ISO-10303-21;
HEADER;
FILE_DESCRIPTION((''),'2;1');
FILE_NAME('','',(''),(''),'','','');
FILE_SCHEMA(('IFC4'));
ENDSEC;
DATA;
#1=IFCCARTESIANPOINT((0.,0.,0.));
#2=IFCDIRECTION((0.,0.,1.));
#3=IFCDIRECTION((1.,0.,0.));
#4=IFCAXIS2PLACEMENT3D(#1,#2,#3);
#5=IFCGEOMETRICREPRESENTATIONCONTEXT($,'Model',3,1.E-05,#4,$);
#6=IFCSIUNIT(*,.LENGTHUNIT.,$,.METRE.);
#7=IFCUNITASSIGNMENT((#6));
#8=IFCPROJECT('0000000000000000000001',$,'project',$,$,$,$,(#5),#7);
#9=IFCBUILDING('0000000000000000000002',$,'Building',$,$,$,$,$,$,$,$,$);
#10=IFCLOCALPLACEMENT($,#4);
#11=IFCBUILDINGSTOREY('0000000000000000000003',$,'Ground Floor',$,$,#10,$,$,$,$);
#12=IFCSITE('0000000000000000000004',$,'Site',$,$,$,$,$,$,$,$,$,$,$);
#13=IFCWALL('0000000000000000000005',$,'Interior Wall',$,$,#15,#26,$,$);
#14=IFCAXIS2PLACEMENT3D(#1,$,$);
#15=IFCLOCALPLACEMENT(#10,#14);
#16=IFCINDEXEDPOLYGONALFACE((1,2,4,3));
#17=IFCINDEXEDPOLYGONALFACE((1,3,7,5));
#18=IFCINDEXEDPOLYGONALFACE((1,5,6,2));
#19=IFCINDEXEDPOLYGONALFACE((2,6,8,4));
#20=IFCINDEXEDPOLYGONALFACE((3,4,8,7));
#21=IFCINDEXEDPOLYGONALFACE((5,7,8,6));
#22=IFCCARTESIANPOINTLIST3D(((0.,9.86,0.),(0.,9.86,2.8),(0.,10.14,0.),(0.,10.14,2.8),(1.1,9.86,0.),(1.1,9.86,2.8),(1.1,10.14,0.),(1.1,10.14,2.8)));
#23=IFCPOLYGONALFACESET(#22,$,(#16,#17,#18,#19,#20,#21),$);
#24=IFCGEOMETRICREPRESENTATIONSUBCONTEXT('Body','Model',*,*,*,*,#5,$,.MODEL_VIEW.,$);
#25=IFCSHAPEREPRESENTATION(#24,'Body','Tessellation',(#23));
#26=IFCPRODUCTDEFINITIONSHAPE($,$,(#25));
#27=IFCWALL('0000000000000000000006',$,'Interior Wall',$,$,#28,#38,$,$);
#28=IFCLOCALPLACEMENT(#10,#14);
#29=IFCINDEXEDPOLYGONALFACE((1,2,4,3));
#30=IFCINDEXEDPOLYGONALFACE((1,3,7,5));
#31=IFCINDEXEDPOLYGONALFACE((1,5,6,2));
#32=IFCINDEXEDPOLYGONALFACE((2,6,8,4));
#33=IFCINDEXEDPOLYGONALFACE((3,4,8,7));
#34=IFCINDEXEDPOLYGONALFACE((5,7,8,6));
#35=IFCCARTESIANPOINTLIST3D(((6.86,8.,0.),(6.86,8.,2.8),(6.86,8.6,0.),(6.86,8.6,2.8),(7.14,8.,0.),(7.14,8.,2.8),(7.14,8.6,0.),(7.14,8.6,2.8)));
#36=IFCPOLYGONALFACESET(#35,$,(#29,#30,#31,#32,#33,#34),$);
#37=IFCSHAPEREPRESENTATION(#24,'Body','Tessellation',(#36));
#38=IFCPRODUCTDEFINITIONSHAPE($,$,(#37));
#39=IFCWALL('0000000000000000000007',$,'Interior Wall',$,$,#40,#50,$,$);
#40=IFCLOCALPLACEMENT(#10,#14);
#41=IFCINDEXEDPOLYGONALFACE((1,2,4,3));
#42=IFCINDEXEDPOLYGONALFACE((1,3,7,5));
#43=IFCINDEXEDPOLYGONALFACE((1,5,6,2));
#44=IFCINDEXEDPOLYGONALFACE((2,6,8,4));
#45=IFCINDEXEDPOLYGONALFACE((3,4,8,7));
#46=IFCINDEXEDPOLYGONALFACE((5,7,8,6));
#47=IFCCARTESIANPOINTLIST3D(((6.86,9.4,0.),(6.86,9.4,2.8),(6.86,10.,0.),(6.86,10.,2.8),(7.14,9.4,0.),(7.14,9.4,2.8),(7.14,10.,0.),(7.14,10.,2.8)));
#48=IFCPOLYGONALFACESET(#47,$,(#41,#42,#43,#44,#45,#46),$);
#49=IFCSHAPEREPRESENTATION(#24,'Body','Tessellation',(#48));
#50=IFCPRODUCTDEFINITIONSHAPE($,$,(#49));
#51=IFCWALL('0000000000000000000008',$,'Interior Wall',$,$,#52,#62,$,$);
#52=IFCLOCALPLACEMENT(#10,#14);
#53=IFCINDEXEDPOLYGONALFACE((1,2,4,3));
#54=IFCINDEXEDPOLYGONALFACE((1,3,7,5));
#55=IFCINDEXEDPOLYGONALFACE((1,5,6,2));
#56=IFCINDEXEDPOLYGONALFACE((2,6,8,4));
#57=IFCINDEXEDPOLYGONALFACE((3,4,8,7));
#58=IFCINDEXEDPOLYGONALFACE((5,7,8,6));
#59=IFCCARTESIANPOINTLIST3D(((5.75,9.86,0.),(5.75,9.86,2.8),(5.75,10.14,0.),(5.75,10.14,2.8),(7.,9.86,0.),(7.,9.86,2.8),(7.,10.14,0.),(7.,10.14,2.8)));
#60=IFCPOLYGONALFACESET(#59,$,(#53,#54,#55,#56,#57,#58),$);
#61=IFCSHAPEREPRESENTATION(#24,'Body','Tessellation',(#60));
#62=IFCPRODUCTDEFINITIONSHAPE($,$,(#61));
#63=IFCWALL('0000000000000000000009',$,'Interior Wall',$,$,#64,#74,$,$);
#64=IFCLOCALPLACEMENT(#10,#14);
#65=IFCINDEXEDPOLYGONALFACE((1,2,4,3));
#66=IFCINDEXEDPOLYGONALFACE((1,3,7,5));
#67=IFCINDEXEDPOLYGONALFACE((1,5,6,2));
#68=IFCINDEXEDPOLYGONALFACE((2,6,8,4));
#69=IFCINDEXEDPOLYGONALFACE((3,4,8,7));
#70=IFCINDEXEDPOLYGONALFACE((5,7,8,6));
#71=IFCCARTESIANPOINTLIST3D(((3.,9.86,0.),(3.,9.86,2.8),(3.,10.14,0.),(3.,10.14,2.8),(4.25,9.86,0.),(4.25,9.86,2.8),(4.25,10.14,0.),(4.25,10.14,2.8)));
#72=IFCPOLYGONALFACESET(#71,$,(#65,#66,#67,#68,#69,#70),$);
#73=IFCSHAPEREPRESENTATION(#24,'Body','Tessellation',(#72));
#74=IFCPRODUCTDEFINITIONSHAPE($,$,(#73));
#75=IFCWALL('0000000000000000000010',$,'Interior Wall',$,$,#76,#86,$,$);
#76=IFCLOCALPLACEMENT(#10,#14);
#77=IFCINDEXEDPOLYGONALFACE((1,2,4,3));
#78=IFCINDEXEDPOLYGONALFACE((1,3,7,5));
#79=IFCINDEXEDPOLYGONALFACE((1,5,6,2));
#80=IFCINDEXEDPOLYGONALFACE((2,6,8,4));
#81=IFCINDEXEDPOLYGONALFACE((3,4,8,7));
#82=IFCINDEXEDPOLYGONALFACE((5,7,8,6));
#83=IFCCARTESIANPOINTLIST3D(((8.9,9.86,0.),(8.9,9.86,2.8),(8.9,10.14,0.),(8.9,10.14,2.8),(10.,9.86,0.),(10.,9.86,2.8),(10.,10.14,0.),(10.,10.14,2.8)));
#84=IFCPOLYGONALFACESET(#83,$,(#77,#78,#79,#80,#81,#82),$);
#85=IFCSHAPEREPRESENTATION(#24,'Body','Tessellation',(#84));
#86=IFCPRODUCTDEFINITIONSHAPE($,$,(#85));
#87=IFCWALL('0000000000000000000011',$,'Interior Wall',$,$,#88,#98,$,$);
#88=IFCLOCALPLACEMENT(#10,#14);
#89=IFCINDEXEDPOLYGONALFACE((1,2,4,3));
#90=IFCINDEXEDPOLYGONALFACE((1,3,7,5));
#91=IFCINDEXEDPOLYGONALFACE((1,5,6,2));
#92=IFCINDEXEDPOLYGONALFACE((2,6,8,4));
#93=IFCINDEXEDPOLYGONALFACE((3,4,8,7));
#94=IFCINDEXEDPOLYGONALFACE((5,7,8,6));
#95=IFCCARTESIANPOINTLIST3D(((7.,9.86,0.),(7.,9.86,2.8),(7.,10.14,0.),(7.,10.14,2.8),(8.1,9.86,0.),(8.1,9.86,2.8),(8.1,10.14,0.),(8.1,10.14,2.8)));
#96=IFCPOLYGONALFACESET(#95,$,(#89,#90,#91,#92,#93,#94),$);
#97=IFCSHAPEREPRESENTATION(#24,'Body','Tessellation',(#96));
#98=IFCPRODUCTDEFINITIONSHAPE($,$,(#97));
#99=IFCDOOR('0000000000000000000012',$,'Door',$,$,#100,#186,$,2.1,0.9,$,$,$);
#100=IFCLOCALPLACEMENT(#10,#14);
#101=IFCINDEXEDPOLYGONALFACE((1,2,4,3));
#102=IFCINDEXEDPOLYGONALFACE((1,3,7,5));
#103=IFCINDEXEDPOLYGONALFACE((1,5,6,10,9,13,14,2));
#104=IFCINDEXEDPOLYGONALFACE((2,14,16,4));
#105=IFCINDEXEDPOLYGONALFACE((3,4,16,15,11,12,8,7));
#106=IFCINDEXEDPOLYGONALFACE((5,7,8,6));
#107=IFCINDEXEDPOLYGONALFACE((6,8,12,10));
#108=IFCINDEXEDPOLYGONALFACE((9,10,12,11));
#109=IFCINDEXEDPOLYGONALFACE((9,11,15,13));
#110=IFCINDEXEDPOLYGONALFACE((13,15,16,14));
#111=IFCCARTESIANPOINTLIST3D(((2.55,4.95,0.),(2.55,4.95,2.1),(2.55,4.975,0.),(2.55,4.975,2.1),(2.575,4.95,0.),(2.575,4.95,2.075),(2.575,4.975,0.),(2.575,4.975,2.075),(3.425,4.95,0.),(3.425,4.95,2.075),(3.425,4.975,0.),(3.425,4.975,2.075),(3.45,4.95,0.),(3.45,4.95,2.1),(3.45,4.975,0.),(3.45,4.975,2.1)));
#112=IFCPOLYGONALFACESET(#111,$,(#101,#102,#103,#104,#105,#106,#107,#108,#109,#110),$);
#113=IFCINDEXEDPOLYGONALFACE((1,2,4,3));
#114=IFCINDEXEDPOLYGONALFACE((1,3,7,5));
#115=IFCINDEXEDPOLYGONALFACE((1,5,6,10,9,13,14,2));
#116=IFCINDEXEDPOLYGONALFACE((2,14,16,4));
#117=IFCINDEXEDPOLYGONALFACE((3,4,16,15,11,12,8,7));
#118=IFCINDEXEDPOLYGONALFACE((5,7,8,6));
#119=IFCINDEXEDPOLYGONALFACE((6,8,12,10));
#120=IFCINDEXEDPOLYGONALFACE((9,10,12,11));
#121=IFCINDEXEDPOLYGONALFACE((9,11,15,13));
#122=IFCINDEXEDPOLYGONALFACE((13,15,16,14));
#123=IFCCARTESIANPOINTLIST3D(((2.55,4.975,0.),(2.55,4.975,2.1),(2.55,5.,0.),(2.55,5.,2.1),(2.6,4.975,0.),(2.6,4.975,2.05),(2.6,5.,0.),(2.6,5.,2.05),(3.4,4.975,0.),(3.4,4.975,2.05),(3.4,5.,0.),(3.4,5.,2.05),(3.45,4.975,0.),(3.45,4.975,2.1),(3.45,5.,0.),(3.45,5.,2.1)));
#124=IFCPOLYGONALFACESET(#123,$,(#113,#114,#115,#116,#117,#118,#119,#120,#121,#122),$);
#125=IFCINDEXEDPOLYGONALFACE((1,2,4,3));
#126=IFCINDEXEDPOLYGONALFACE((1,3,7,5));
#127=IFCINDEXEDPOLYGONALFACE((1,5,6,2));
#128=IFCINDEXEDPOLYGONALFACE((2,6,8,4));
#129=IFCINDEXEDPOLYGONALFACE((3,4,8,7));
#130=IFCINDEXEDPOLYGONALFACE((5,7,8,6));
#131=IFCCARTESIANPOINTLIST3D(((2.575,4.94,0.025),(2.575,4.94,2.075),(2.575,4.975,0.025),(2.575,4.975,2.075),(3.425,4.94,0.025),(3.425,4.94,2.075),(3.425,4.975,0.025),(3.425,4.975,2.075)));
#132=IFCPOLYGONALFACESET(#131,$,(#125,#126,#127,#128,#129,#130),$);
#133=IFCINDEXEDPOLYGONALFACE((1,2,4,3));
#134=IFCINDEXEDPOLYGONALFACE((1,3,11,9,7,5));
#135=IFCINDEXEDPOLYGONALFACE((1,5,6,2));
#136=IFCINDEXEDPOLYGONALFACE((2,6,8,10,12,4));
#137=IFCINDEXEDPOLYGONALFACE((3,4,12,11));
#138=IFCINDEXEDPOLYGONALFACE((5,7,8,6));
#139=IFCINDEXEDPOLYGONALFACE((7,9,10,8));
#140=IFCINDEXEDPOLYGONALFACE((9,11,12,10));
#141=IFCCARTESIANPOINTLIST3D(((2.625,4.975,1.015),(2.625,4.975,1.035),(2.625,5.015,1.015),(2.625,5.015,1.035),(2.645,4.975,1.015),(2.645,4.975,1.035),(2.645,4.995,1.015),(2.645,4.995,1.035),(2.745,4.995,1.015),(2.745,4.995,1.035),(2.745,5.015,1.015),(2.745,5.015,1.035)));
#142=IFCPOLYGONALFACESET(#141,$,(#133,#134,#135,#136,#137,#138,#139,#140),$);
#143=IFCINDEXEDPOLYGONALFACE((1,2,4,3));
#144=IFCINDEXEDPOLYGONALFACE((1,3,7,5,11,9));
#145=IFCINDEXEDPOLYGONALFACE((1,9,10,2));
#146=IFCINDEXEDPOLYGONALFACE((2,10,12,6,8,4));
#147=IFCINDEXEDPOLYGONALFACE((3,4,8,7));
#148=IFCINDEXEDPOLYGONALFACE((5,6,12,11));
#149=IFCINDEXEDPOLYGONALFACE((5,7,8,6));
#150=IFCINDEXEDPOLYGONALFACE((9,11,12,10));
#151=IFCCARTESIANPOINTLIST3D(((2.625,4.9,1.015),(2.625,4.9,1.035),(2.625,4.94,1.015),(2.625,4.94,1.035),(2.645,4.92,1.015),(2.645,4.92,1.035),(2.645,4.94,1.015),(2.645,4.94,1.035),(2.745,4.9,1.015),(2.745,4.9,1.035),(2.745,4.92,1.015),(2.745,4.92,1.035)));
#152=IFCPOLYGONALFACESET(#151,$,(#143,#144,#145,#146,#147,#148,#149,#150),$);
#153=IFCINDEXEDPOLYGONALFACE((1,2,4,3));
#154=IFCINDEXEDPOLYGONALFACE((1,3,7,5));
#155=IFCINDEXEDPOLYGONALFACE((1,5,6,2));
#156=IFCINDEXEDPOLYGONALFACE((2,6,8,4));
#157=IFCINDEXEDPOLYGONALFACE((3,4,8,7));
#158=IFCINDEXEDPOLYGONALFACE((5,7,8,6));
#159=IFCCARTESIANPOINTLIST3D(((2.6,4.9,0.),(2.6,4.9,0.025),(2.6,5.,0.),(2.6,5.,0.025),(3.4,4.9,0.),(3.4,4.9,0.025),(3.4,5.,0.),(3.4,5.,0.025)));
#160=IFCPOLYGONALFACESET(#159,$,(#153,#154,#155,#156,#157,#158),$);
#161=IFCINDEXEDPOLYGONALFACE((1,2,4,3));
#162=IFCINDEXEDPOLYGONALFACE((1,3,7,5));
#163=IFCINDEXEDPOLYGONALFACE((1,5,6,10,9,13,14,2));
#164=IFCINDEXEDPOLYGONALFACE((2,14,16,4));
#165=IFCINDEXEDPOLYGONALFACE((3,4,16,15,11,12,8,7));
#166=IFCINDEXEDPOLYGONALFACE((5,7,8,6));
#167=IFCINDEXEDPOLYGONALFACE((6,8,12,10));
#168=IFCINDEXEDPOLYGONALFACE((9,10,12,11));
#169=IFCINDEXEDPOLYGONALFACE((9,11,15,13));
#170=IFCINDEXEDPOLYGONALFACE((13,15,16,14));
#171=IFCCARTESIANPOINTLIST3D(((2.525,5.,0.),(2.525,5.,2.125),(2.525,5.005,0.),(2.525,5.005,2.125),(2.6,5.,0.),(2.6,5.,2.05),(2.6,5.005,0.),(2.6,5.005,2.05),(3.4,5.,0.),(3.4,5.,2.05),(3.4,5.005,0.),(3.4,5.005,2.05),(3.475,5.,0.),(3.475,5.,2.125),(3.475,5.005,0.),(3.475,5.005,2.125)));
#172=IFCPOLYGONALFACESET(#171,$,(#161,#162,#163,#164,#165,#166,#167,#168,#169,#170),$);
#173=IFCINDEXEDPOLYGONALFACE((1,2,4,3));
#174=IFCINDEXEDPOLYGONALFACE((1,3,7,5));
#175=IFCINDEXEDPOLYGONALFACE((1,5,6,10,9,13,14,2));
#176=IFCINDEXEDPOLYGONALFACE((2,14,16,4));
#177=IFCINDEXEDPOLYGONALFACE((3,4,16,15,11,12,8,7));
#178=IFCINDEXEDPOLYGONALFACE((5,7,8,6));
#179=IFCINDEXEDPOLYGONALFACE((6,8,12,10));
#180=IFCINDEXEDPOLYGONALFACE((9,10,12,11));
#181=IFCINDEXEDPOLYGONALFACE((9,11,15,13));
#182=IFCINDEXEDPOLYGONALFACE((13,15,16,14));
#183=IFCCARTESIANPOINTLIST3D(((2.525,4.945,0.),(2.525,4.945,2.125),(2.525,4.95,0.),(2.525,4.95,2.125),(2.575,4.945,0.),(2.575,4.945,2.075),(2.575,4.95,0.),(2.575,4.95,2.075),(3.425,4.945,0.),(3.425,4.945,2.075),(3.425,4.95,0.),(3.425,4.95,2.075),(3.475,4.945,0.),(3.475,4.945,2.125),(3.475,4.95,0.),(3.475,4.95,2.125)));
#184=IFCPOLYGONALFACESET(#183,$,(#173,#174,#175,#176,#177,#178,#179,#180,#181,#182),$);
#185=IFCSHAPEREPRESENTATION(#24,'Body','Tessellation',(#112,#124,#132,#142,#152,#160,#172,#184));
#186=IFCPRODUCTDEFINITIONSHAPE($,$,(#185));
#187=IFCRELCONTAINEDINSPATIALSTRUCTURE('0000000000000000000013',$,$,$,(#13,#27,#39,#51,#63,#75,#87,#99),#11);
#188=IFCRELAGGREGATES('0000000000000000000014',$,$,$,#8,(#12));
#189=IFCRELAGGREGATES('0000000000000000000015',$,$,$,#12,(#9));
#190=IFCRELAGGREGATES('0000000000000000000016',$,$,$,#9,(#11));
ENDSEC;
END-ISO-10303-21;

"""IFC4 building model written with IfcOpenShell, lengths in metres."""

from ifc_helpers import new_model, si_unit, frame, origin_with_axes, place, context, subcontext, project, spatial, line, indexed_curve, outline, extrude, element, save


model = new_model("IFC4")

# Units and contexts
model_context = context("Model", 3, precision=1e-05, world=origin_with_axes())
body_context = subcontext(model_context, "Body", "Model", "MODEL_VIEW")
ifc_project = project(units=[si_unit("LENGTHUNIT", "METRE")], contexts=[model_context])

# Site, building, storey
site = spatial("IfcSite", under=ifc_project, Name="Site")
building = spatial("IfcBuilding", under=site, Name="Building")
storey_placement = place(None, origin_with_axes())
storey = spatial("IfcBuildingStorey", under=building, at=storey_placement, Name="Ground Floor")

# Walls
for number, where, z_axis, x_axis, name in (
    (1, (1.1, 10.0, 0.0), (0.0, 0.0, 1.0), (-1.0, 0.0, 0.0), "Interior Wall"),
):
    element("IfcWall", number, at=place(storey_placement, frame(where, z_axis=z_axis, x_axis=x_axis)), inside=storey, Name=name, context=body_context, shape_type="SweptSolid", body=[
        extrude(outline(indexed_curve([(0.0, 0.0), (0.0, 0.28), (1.1, 0.28), (1.1, 0.0), (0.0, 0.0)], self_intersect=False)), frame((0.0, -0.14, 0.0), z_axis=(0.0, 0.0, 1.0), x_axis=(1.0, 0.0, 0.0)), (0.0, 0.0, 1.0), 2.8),
    ])
for number, where, z_axis, x_axis, name in (
    (2, (7.0, 8.0, 0.0), (0.0, 0.0, 1.0), (0.0, 1.0, 0.0), "Interior Wall"),
    (3, (7.0, 9.4, 0.0), (0.0, 0.0, 1.0), (0.0, 1.0, 0.0), "Interior Wall"),
):
    element("IfcWall", number, at=place(storey_placement, frame(where, z_axis=z_axis, x_axis=x_axis)), inside=storey, Name=name, context=body_context, shape_type="SweptSolid", body=[
        extrude(outline(indexed_curve([(0.0, 0.0), (0.0, 0.28), (0.6, 0.28), (0.6, 0.0), (0.0, 0.0)], self_intersect=False)), frame((0.0, -0.14, 0.0), z_axis=(0.0, 0.0, 1.0), x_axis=(1.0, 0.0, 0.0)), (0.0, 0.0, 1.0), 2.8),
    ])
for number, where, z_axis, x_axis, name in (
    (4, (7.0, 10.0, 0.0), (0.0, 0.0, 1.0), (-1.0, 0.0, 0.0), "Interior Wall"),
    (5, (4.25, 10.0, 0.0), (0.0, 0.0, 1.0), (-1.0, 0.0, 0.0), "Interior Wall"),
):
    element("IfcWall", number, at=place(storey_placement, frame(where, z_axis=z_axis, x_axis=x_axis)), inside=storey, Name=name, context=body_context, shape_type="SweptSolid", body=[
        extrude(outline(indexed_curve([(0.0, 0.0), (0.0, 0.28), (1.25, 0.28), (1.25, 0.0), (0.0, 0.0)], self_intersect=False)), frame((0.0, -0.14, 0.0), z_axis=(0.0, 0.0, 1.0), x_axis=(1.0, 0.0, 0.0)), (0.0, 0.0, 1.0), 2.8),
    ])
for number, where, z_axis, x_axis, name in (
    (6, (10.0, 10.0, 0.0), (0.0, 0.0, 1.0), (-1.0, 0.0, 0.0), "Interior Wall"),
    (7, (8.1, 10.0, 0.0), (0.0, 0.0, 1.0), (-1.0, 0.0, 0.0), "Interior Wall"),
):
    element("IfcWall", number, at=place(storey_placement, frame(where, z_axis=z_axis, x_axis=x_axis)), inside=storey, Name=name, context=body_context, shape_type="SweptSolid", body=[
        extrude(outline(indexed_curve([(0.0, 0.0), (0.0, 0.28), (1.1, 0.28), (1.1, 0.0), (0.0, 0.0)], self_intersect=False)), frame((0.0, -0.14, 0.0), z_axis=(0.0, 0.0, 1.0), x_axis=(1.0, 0.0, 0.0)), (0.0, 0.0, 1.0), 2.8),
    ])

# Door
door_1_placement = place(storey_placement, frame((3.45, 5.0, 0.0), z_axis=(0.0, 0.0, 1.0), x_axis=(-1.0, 0.0, 0.0)))
element("IfcDoor", 8, at=door_1_placement, inside=storey, Name="Door", OverallHeight=2.1, OverallWidth=0.9, context=body_context, shape_type="SweptSolid", body=[
    extrude(outline(indexed_curve([(0.0, 0.0), (0.0, 2.1), (0.9, 2.1), (0.9, 0.0), (0.875, 0.0), (0.875, 2.075), (0.025, 2.075), (0.025, 0.0)], segments=[line(1, 2, 3, 4, 5, 6, 7, 8, 1)])), frame((0.0, 0.025, 0.0), z_axis=(0.0, -1.0, 0.0), x_axis=(1.0, 0.0, 0.0)), (0.0, 0.0, -1.0), 0.025),
    extrude(outline(indexed_curve([(0.0, 0.0), (0.0, 2.1), (0.9, 2.1), (0.9, 0.0), (0.85, 0.0), (0.85, 2.05), (0.05, 2.05), (0.05, 0.0)], segments=[line(1, 2, 3, 4, 5, 6, 7, 8, 1)])), frame((0.0, 0.0, 0.0), z_axis=(0.0, -1.0, 0.0), x_axis=(1.0, 0.0, 0.0)), (0.0, 0.0, -1.0), 0.025),
    extrude(outline(indexed_curve([(0.0, 0.0), (0.85, 0.0), (0.85, 0.035), (0.0, 0.035)], segments=[line(1, 2, 3, 4, 1)])), frame((0.025, 0.025, 0.025), z_axis=(0.0, 0.0, 1.0), x_axis=(1.0, 0.0, 0.0)), (0.0, 0.0, 1.0), 2.05),
    extrude(outline(indexed_curve([(0.0, 0.0), (0.0, -0.04), (-0.12, -0.04), (-0.12, -0.02), (-0.02, -0.02), (-0.02, 0.0)], segments=[line(1, 2, 3, 4, 5, 6, 1)])), frame((0.825, 0.025, 1.015), z_axis=(0.0, 0.0, 1.0), x_axis=(1.0, 0.0, 0.0)), (0.0, 0.0, 1.0), 0.02),
    extrude(outline(indexed_curve([(0.0, 0.0), (0.0, 0.04), (-0.12, 0.04), (-0.12, 0.02), (-0.02, 0.02), (-0.02, 0.0)], segments=[line(1, 2, 3, 4, 5, 6, 1)])), frame((0.825, 0.06, 1.015), z_axis=(0.0, 0.0, 1.0), x_axis=(1.0, 0.0, 0.0)), (0.0, 0.0, 1.0), 0.02),
    extrude(outline(indexed_curve([(0.0, 0.0), (0.8, 0.0), (0.8, 0.1), (0.0, 0.1)], segments=[line(1, 2, 3, 4, 1)])), frame((0.05, 0.0, 0.0), z_axis=(0.0, 0.0, 1.0), x_axis=(1.0, 0.0, 0.0)), (0.0, 0.0, 1.0), 0.025),
    extrude(outline(indexed_curve([(0.0, 0.0), (0.0, 2.125), (0.95, 2.125), (0.95, 0.0), (0.875, 0.0), (0.875, 2.05), (0.075, 2.05), (0.075, 0.0)], segments=[line(1, 2, 3, 4, 5, 6, 7, 8, 1)])), frame((-0.025, -0.005, 0.0), z_axis=(0.0, -1.0, 0.0), x_axis=(1.0, 0.0, 0.0)), (0.0, 0.0, -1.0), 0.005),
    extrude(outline(indexed_curve([(0.0, 0.0), (0.0, 2.125), (0.95, 2.125), (0.95, 0.0), (0.9, 0.0), (0.9, 2.075), (0.05, 2.075), (0.05, 0.0)], segments=[line(1, 2, 3, 4, 5, 6, 7, 8, 1)])), frame((-0.025, 0.05, 0.0), z_axis=(0.0, -1.0, 0.0), x_axis=(1.0, 0.0, 0.0)), (0.0, 0.0, -1.0), 0.005),
])

save(model, "model.ifc")
